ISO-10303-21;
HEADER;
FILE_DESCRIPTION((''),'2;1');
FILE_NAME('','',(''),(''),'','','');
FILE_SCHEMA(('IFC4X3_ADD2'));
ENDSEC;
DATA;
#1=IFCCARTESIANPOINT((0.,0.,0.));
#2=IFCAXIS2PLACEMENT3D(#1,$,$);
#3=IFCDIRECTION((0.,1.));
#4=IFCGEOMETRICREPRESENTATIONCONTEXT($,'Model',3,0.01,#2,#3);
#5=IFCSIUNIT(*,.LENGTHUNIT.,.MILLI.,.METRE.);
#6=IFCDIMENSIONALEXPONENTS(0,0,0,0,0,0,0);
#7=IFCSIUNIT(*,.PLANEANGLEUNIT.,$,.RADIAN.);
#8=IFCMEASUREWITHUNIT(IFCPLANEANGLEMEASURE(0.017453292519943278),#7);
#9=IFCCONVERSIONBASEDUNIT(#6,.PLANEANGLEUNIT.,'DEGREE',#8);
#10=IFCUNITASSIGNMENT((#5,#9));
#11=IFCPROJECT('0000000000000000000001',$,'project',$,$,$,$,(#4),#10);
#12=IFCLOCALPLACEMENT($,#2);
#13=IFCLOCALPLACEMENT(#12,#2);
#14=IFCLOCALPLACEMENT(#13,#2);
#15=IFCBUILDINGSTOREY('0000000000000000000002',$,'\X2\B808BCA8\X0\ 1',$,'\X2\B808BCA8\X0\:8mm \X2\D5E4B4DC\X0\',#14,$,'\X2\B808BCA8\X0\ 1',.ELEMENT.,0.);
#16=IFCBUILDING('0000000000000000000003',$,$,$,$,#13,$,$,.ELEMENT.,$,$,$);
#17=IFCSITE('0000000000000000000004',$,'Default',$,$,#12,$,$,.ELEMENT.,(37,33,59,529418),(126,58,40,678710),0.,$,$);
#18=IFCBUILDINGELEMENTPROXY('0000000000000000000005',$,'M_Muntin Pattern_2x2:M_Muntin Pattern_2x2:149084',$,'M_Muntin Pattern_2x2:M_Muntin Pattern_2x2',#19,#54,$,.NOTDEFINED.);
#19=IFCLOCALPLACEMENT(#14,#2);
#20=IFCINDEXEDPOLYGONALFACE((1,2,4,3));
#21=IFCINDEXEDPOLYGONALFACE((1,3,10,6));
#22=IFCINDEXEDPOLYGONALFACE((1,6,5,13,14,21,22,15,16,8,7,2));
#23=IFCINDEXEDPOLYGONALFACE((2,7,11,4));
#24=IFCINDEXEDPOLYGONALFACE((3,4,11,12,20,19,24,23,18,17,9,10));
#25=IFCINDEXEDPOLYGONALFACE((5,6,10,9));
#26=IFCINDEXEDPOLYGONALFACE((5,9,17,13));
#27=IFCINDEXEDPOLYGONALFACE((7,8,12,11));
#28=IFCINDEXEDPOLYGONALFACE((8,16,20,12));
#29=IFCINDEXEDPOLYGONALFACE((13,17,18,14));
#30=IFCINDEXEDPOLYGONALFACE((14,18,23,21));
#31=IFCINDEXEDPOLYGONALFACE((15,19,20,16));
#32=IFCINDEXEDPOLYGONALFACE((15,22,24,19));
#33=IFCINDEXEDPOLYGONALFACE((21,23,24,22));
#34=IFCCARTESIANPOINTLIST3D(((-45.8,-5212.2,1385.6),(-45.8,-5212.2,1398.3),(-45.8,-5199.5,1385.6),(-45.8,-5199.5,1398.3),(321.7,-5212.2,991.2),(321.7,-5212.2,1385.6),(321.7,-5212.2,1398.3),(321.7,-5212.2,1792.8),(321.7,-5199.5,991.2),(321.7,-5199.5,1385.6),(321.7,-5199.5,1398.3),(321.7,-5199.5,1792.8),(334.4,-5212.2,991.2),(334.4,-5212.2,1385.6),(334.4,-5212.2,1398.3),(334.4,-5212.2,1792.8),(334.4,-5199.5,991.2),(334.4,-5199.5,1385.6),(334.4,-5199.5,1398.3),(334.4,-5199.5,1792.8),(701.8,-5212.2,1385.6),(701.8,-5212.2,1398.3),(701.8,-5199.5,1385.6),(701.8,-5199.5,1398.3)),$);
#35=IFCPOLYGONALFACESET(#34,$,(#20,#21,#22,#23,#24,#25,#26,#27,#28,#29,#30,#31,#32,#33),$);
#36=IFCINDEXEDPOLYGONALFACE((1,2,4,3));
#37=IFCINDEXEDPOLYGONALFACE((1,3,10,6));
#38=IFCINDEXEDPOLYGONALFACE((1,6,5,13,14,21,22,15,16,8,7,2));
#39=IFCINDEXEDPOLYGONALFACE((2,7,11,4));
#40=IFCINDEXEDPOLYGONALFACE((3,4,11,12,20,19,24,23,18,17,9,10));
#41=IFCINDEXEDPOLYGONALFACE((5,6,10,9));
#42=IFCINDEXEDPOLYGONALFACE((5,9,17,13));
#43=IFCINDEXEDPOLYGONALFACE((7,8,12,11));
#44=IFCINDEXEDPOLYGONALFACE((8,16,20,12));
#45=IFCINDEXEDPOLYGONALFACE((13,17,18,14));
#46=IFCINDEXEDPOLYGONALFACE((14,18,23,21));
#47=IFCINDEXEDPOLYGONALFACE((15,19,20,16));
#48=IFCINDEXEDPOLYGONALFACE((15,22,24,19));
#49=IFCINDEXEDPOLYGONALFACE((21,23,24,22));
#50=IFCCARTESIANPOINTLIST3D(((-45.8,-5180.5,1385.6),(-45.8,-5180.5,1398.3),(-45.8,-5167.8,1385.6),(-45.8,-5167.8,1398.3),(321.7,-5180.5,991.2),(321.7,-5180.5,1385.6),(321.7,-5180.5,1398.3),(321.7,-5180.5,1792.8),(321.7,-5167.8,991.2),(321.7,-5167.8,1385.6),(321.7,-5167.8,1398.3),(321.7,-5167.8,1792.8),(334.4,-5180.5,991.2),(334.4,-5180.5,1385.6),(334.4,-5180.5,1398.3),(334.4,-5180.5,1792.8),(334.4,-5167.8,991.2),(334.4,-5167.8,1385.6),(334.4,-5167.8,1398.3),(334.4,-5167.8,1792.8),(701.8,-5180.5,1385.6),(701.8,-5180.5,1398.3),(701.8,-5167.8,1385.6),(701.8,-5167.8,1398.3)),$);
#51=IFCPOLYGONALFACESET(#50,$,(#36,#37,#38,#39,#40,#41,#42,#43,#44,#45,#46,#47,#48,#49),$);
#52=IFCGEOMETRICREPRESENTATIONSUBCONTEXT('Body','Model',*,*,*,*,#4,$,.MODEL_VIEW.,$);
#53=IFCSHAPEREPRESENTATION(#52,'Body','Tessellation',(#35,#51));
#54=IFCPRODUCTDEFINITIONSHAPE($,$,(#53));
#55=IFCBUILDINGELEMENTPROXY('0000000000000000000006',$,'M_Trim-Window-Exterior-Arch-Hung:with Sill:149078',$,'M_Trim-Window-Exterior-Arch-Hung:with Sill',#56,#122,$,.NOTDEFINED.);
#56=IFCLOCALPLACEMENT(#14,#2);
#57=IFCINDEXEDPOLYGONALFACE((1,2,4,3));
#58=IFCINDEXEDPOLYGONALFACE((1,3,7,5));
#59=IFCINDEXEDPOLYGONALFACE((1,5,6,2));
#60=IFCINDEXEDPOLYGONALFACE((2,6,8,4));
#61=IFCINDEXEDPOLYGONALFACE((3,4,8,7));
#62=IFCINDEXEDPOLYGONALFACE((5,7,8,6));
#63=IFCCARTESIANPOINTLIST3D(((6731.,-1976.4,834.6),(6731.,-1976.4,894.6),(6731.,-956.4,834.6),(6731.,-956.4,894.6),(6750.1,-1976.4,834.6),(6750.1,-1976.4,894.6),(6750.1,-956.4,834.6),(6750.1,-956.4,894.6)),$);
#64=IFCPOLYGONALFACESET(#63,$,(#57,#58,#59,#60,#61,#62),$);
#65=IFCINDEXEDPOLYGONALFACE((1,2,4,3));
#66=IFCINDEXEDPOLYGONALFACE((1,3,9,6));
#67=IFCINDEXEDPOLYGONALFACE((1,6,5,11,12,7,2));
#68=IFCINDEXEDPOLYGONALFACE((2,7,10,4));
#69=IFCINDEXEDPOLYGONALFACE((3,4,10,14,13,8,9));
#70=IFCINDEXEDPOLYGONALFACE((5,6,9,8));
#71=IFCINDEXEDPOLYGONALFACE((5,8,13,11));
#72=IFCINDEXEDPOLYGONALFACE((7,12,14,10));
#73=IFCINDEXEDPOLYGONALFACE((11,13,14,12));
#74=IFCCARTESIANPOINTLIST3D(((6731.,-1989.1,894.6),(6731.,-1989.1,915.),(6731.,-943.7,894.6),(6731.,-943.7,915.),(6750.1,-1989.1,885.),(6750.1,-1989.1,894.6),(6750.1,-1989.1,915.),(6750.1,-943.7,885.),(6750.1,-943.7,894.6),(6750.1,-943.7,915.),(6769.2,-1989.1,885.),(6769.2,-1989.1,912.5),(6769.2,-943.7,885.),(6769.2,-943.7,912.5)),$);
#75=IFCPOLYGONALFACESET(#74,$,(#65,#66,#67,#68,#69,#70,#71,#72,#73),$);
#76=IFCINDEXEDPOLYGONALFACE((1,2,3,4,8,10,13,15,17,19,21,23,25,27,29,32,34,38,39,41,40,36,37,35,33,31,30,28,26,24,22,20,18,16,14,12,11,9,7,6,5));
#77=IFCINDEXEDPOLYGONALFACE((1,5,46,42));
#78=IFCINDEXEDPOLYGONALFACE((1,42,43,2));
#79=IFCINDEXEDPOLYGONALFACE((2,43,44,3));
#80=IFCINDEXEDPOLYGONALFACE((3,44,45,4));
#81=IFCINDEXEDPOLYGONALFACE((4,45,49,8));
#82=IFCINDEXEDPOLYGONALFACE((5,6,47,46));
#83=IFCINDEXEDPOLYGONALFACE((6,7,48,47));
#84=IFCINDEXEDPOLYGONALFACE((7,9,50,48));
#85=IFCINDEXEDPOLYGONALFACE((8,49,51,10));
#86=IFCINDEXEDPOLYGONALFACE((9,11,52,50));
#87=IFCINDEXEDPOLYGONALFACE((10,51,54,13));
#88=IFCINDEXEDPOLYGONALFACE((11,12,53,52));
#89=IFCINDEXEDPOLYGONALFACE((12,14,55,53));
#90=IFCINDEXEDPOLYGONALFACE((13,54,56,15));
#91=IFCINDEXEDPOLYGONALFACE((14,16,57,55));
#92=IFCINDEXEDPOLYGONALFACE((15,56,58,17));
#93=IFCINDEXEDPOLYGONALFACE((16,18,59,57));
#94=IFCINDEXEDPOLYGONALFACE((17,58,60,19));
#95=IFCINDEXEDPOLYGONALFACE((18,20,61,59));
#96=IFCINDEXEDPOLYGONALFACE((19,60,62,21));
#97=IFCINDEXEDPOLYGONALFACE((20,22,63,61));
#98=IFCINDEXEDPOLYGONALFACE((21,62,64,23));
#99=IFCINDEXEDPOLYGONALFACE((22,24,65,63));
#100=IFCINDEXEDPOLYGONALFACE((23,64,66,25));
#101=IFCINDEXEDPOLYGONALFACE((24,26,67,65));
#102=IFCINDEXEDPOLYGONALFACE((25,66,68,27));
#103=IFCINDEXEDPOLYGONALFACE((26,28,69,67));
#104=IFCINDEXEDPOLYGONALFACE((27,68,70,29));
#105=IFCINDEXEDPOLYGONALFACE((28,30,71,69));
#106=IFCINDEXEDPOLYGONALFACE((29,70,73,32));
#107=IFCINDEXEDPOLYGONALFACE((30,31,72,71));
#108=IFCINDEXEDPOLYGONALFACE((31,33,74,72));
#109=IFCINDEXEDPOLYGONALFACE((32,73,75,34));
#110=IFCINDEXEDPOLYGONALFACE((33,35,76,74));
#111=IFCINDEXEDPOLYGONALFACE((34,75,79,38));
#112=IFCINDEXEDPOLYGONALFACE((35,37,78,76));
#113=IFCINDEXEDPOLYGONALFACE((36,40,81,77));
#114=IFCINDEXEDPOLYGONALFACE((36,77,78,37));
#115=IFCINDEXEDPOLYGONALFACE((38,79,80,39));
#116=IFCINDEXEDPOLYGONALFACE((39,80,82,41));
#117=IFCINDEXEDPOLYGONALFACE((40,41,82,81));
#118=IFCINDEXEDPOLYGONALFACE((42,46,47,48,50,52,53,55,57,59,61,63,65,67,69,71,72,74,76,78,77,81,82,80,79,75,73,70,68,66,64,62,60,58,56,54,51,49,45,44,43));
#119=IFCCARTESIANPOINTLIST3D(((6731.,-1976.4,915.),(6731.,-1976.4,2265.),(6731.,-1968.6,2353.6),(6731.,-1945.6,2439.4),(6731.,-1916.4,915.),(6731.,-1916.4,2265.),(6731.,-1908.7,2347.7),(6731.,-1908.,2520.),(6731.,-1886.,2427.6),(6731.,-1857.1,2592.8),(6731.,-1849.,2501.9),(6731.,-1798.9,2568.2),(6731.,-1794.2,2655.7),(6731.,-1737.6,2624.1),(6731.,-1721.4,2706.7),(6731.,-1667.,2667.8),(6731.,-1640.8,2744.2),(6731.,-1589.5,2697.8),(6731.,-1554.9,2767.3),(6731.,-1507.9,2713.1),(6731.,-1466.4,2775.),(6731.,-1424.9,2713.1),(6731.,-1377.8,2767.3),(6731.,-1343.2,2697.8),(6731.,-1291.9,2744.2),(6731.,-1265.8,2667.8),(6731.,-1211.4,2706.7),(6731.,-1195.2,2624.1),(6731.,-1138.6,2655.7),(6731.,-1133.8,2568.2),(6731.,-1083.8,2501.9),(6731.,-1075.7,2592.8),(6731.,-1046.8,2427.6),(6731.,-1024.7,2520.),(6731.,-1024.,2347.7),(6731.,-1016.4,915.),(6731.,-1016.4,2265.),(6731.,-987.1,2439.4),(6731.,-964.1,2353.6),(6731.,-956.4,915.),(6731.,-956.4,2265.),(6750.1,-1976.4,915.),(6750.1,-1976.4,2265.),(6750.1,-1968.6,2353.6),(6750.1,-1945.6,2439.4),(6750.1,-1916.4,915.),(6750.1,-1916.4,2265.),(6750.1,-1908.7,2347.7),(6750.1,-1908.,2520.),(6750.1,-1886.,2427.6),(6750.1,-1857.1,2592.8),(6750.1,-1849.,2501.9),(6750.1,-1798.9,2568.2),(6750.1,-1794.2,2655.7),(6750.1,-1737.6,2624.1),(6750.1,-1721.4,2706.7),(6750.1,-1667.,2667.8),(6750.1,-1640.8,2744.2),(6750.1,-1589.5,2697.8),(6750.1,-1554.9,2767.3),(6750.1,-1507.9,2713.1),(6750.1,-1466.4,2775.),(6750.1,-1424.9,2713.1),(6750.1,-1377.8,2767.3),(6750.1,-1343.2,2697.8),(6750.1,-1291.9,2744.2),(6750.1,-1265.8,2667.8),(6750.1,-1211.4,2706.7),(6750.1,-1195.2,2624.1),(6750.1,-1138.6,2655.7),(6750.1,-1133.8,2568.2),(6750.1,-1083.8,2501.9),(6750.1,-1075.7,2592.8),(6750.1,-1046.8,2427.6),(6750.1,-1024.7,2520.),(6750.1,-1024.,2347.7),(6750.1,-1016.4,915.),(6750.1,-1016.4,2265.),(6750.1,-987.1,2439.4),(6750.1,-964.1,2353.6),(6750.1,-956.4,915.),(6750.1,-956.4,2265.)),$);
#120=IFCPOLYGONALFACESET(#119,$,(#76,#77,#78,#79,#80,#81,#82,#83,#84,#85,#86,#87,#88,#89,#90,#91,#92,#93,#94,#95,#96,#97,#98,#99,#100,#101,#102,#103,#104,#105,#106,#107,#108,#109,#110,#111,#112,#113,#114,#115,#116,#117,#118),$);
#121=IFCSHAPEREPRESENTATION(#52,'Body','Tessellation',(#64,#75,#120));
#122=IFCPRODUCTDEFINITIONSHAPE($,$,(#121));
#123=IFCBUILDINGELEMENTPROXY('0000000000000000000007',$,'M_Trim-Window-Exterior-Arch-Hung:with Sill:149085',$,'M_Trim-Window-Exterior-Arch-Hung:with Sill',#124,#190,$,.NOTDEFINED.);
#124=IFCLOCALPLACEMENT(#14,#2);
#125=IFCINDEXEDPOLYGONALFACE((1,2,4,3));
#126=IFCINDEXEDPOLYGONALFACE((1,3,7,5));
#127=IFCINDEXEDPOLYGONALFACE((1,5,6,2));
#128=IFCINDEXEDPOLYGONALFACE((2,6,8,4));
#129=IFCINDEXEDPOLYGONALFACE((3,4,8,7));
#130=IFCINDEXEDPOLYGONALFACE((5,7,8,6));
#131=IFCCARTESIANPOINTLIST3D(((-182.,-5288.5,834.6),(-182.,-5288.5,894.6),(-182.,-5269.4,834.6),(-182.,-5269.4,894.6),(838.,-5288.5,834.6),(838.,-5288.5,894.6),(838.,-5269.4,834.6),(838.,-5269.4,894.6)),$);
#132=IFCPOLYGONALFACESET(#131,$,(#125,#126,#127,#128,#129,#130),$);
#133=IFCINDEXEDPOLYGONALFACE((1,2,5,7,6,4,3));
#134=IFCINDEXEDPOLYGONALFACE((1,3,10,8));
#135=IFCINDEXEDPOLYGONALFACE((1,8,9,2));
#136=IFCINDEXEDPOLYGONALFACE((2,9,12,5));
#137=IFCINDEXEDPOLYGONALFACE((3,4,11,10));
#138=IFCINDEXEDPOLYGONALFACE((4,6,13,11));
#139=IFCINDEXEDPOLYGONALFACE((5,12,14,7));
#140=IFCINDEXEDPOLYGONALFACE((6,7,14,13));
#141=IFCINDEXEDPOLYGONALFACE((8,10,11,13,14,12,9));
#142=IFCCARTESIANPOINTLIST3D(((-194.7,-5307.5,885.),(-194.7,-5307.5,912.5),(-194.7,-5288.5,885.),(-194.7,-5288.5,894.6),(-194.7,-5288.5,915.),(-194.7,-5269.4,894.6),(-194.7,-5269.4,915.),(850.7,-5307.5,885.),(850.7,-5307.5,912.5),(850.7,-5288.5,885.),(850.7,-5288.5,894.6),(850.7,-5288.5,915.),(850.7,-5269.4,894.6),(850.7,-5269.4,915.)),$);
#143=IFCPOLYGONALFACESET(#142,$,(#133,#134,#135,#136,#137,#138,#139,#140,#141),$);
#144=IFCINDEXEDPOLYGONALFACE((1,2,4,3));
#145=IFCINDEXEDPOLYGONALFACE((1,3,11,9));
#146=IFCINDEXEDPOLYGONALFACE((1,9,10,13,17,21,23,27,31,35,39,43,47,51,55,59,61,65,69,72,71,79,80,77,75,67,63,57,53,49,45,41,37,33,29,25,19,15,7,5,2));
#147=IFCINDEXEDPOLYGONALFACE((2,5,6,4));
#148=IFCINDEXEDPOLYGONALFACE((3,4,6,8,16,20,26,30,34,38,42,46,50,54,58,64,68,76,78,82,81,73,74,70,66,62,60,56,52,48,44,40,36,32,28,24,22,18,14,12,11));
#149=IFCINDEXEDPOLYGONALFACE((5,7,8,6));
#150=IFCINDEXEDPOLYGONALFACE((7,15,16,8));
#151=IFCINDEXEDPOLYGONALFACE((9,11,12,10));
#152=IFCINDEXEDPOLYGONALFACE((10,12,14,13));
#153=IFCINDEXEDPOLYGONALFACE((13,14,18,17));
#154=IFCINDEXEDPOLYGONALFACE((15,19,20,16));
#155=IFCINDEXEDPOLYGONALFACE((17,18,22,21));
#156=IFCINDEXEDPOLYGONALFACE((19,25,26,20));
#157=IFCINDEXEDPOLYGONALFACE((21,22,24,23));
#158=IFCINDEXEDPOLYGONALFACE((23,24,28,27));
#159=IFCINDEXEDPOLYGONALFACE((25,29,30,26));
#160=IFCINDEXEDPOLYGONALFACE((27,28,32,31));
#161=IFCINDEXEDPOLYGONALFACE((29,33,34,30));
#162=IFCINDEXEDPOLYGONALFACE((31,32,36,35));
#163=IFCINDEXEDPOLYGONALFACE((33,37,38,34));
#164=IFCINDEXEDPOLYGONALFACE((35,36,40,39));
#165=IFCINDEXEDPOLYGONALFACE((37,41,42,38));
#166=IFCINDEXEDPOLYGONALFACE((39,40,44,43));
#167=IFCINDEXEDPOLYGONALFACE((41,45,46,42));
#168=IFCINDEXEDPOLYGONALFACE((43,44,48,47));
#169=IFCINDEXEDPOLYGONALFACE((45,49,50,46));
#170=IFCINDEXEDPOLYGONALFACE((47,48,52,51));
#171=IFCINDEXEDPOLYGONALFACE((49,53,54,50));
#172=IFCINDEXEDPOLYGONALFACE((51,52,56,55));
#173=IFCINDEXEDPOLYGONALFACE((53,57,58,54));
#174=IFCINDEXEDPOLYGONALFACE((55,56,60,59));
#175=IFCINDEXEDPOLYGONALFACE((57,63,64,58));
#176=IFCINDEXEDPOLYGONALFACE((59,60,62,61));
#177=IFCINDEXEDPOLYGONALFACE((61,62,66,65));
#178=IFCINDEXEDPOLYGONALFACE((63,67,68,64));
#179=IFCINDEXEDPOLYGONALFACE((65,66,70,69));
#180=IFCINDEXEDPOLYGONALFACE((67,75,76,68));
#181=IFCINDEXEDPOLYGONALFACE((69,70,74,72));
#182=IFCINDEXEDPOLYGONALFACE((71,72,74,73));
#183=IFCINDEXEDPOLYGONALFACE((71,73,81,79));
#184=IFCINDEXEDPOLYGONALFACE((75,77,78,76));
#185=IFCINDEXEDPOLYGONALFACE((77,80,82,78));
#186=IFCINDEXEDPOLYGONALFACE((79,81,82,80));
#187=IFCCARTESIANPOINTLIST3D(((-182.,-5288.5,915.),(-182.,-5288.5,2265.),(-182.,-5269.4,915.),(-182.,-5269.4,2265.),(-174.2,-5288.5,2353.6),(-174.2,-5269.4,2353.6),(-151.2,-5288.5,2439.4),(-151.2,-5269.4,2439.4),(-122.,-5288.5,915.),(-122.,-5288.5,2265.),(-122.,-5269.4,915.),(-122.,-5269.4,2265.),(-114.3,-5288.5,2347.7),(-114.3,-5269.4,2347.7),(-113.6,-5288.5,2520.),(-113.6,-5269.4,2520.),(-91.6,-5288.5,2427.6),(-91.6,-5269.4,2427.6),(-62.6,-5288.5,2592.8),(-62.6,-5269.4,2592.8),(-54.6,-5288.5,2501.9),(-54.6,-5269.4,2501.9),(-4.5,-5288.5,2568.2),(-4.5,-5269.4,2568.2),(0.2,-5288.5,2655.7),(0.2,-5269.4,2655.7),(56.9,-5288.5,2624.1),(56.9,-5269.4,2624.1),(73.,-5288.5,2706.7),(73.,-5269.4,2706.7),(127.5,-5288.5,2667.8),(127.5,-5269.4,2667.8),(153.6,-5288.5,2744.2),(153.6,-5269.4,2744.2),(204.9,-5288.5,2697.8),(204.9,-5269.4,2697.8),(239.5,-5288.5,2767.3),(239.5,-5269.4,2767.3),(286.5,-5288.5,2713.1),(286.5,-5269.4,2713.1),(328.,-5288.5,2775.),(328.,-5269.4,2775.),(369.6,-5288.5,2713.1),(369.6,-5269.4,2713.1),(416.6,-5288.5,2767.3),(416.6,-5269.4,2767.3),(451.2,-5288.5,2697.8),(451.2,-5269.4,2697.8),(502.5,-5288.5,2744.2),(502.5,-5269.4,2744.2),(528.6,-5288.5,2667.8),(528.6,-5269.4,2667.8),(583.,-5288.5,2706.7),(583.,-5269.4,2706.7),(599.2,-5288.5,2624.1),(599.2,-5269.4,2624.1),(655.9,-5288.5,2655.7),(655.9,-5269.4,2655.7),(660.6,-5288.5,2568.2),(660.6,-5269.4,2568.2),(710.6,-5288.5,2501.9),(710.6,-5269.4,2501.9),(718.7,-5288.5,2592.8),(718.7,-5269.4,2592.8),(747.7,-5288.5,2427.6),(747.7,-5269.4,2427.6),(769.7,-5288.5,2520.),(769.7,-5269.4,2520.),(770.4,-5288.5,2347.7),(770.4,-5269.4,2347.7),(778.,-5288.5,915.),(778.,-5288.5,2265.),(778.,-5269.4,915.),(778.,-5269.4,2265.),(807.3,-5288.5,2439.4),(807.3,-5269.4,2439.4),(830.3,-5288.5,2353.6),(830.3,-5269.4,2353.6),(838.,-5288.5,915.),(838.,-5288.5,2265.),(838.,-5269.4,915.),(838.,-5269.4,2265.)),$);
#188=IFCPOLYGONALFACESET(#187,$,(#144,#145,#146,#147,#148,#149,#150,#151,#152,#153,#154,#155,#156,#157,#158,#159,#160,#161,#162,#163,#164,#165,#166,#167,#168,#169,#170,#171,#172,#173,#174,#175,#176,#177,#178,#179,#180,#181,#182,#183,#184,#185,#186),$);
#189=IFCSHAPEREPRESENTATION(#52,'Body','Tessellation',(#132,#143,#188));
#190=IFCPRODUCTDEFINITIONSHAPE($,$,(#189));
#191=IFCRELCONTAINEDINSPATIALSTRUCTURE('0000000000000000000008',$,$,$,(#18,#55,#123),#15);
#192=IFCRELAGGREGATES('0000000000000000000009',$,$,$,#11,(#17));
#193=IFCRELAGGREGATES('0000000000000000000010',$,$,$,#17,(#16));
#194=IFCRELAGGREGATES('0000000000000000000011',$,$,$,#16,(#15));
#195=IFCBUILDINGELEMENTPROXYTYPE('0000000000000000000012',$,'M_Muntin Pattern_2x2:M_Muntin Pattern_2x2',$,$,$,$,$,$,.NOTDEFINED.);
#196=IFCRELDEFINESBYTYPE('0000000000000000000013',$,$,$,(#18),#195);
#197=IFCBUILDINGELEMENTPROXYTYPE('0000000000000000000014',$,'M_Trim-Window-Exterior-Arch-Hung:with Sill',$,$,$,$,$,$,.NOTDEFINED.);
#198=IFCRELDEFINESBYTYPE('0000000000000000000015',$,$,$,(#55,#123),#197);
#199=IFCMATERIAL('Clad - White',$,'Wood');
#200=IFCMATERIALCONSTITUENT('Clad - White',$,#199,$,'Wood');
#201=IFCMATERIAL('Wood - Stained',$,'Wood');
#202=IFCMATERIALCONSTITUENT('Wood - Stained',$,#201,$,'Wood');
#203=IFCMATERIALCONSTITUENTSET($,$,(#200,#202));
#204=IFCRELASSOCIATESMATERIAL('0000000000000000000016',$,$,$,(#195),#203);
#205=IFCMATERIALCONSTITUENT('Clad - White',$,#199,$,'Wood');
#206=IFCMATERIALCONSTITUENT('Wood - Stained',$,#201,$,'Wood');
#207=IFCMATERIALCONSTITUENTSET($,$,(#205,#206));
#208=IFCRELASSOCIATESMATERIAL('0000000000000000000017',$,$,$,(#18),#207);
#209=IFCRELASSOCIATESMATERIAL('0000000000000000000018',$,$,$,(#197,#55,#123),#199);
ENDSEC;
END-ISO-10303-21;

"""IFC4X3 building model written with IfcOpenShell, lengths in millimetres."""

from ifc_helpers import new_model, entity, si_unit, converted_unit, direction, frame, frame_2d, origin, place, context, subcontext, project, spatial, polyline, circle_curve, parameter, trimmed, segment, composite_curve, rectangle, outline, extrude, source, transform, mapped, material, constituent, constituent_set, type_object, type_shapes, element, save


model = new_model("IFC4X3")

# Units and contexts
model_context = context("Model", 3, precision=0.01, world=origin(), true_north=direction((0.0, 1.0)))
body_context = subcontext(model_context, "Body", "Model", "MODEL_VIEW")
ifc_project = project(units=[si_unit("LENGTHUNIT", "METRE", prefix="MILLI"), converted_unit("PLANEANGLEUNIT", "DEGREE", entity("IfcPlaneAngleMeasure", 0.017453292519943278), si_unit("PLANEANGLEUNIT", "RADIAN"), dimensions=[0, 0, 0, 0, 0, 0, 0])], contexts=[model_context])

# Site, building, storey
site_placement = place(None, origin())
site = spatial("IfcSite", under=ifc_project, at=site_placement, Name="Default", CompositionType="ELEMENT", RefLatitude=(37, 33, 59, 529418), RefLongitude=(126, 58, 40, 678710), RefElevation=0.0)
building_placement = place(site_placement, origin())
building = spatial("IfcBuilding", under=site, at=building_placement, CompositionType="ELEMENT")
storey_placement = place(building_placement, origin())
storey = spatial("IfcBuildingStorey", under=building, at=storey_placement, Name="레벨 1", ObjectType="레벨:8mm 헤드", LongName="레벨 1", CompositionType="ELEMENT", Elevation=0.0)

# Building element proxies
ifc_material_1 = material(Name="Clad - White", Category="Wood")
ifc_material_2 = material(Name="Wood - Stained", Category="Wood")
ifc_constituent_1 = constituent(ifc_material_1, Name="Clad - White", Category="Wood")
ifc_constituent_2 = constituent(ifc_material_2, Name="Wood - Stained", Category="Wood")
ifc_constituent_set_1 = constituent_set(constituents=[ifc_constituent_1, ifc_constituent_2])
building_element_proxy_type_1 = type_object("IfcBuildingElementProxyType", Name="M_Muntin Pattern_2x2:M_Muntin Pattern_2x2", PredefinedType="NOTDEFINED", material=ifc_constituent_set_1)
shared_shape_1 = source(origin(), body_context, "Body", "SweptSolid", [
    extrude(outline(polyline([(6.4, -6.4), (400.8, -6.4), (400.8, 6.3), (6.4, 6.3), (6.4, 373.8), (-6.3, 373.8), (-6.3, 6.3), (-400.8, 6.3), (-400.8, -6.4), (-6.3, -6.4), (-6.3, -373.8), (6.4, -373.8), (6.4, -6.4)])), frame((0.0, 9.5, 400.8), z_axis=(0.0, 1.0, 0.0), x_axis=(0.0, 0.0, 1.0)), (0.0, 0.0, 1.0), 12.7),
    extrude(outline(polyline([(6.4, -6.4), (400.8, -6.4), (400.8, 6.3), (6.4, 6.3), (6.4, 373.8), (-6.3, 373.8), (-6.3, 6.3), (-400.8, 6.3), (-400.8, -6.4), (-6.3, -6.4), (-6.3, -373.8), (6.4, -373.8), (6.4, -6.4)])), frame((0.0, -22.2, 400.8), z_axis=(0.0, 1.0, 0.0), x_axis=(0.0, 0.0, 1.0)), (0.0, 0.0, 1.0), 12.7),
])
type_shapes(building_element_proxy_type_1, [shared_shape_1])
ifc_constituent_3 = constituent(ifc_material_1, Name="Clad - White", Category="Wood")
ifc_constituent_4 = constituent(ifc_material_2, Name="Wood - Stained", Category="Wood")
ifc_constituent_set_2 = constituent_set(constituents=[ifc_constituent_3, ifc_constituent_4])
proxy_1_placement = place(storey_placement, frame((328.0, -5190.0, 991.2), z_axis=(0.0, 0.0, 1.0), x_axis=(-1.0, 0.0, 0.0)))
element("IfcBuildingElementProxy", 1, at=proxy_1_placement, inside=storey, type_object=building_element_proxy_type_1, material=ifc_constituent_set_2, Name="M_Muntin Pattern_2x2:M_Muntin Pattern_2x2:149084", ObjectType="M_Muntin Pattern_2x2:M_Muntin Pattern_2x2", PredefinedType="NOTDEFINED", context=body_context, shape_type="MappedRepresentation", body=[
    mapped(shared_shape_1, transform((0.0, 0.0, 0.0), scale=1.0)),
])
building_element_proxy_type_2 = type_object("IfcBuildingElementProxyType", Name="M_Trim-Window-Exterior-Arch-Hung:with Sill", PredefinedType="NOTDEFINED", material=ifc_material_1)
shared_shape_2 = source(origin(), body_context, "Body", "SweptSolid", [
    extrude(rectangle(XDim=1020.0, YDim=60.0, at=frame_2d((0.0, 0.0), x_axis=(1.0, 0.0))), frame((0.0, -1850.4, 0.0), z_axis=(0.0, 0.0, 1.0), x_axis=(-1.0, 0.0, 0.0)), (0.0, 0.0, 1.0), 19.1),
    extrude(outline(polyline([(-19.1, -15.2), (0.0, -15.2), (0.0, -5.7), (19.1, -5.7), (19.1, 14.8), (0.0, 14.8), (-19.1, 12.3), (-19.1, -15.2)])), frame((-522.7, -1814.8, 19.1), z_axis=(1.0, 0.0, 0.0), x_axis=(0.0, 0.0, -1.0)), (0.0, 0.0, 1.0), 1045.4),
    extrude(outline(composite_curve([segment(polyline([(-675.0, -510.0), (675.0, -510.0)]), True, "CONTINUOUS"), segment(polyline([(675.0, -510.0), (675.0, -450.0)]), True, "CONTINUOUS"), segment(polyline([(675.0, -450.0), (-675.0, -450.0)]), True, "CONTINUOUS"), segment(trimmed(circle_curve(frame_2d((-675.0, 0.0), x_axis=(0.0, 1.0)), 450.0), [parameter(0.0)], [parameter(180.0)], True, "PARAMETER"), False, "CONTINUOUS"), segment(polyline([(-675.0, 450.0), (675.0, 450.0)]), True, "CONTINUOUS"), segment(polyline([(675.0, 450.0), (675.0, 510.0)]), True, "CONTINUOUS"), segment(polyline([(675.0, 510.0), (-675.0, 510.0)]), True, "CONTINUOUS"), segment(trimmed(circle_curve(frame_2d((-675.0, 0.0), x_axis=(0.0, 1.0)), 510.0), [parameter(0.0)], [parameter(180.0)], True, "PARAMETER"), True, "CONTINUOUS")], self_intersect=False)), frame((0.0, -1125.0, 0.0), z_axis=(0.0, 0.0, 1.0), x_axis=(0.0, -1.0, 0.0)), (0.0, 0.0, 1.0), 19.1),
])
type_shapes(building_element_proxy_type_2, [shared_shape_2])
for number, where, z_axis, x_axis, name in (
    (2, (6731.0, -1466.4, 2715.0), (1.0, 0.0, 0.0), (0.0, 1.0, 0.0), "M_Trim-Window-Exterior-Arch-Hung:with Sill:149078"),
    (3, (328.0, -5269.4, 2715.0), (0.0, -1.0, 0.0), (1.0, 0.0, 0.0), "M_Trim-Window-Exterior-Arch-Hung:with Sill:149085"),
):
    element("IfcBuildingElementProxy", number, at=place(storey_placement, frame(where, z_axis=z_axis, x_axis=x_axis)), inside=storey, type_object=building_element_proxy_type_2, material=ifc_material_1, Name=name, ObjectType="M_Trim-Window-Exterior-Arch-Hung:with Sill", PredefinedType="NOTDEFINED", context=body_context, shape_type="MappedRepresentation", body=[
        mapped(shared_shape_2, transform((0.0, 0.0, 0.0), scale=1.0)),
    ])

save(model, "model.ifc")
